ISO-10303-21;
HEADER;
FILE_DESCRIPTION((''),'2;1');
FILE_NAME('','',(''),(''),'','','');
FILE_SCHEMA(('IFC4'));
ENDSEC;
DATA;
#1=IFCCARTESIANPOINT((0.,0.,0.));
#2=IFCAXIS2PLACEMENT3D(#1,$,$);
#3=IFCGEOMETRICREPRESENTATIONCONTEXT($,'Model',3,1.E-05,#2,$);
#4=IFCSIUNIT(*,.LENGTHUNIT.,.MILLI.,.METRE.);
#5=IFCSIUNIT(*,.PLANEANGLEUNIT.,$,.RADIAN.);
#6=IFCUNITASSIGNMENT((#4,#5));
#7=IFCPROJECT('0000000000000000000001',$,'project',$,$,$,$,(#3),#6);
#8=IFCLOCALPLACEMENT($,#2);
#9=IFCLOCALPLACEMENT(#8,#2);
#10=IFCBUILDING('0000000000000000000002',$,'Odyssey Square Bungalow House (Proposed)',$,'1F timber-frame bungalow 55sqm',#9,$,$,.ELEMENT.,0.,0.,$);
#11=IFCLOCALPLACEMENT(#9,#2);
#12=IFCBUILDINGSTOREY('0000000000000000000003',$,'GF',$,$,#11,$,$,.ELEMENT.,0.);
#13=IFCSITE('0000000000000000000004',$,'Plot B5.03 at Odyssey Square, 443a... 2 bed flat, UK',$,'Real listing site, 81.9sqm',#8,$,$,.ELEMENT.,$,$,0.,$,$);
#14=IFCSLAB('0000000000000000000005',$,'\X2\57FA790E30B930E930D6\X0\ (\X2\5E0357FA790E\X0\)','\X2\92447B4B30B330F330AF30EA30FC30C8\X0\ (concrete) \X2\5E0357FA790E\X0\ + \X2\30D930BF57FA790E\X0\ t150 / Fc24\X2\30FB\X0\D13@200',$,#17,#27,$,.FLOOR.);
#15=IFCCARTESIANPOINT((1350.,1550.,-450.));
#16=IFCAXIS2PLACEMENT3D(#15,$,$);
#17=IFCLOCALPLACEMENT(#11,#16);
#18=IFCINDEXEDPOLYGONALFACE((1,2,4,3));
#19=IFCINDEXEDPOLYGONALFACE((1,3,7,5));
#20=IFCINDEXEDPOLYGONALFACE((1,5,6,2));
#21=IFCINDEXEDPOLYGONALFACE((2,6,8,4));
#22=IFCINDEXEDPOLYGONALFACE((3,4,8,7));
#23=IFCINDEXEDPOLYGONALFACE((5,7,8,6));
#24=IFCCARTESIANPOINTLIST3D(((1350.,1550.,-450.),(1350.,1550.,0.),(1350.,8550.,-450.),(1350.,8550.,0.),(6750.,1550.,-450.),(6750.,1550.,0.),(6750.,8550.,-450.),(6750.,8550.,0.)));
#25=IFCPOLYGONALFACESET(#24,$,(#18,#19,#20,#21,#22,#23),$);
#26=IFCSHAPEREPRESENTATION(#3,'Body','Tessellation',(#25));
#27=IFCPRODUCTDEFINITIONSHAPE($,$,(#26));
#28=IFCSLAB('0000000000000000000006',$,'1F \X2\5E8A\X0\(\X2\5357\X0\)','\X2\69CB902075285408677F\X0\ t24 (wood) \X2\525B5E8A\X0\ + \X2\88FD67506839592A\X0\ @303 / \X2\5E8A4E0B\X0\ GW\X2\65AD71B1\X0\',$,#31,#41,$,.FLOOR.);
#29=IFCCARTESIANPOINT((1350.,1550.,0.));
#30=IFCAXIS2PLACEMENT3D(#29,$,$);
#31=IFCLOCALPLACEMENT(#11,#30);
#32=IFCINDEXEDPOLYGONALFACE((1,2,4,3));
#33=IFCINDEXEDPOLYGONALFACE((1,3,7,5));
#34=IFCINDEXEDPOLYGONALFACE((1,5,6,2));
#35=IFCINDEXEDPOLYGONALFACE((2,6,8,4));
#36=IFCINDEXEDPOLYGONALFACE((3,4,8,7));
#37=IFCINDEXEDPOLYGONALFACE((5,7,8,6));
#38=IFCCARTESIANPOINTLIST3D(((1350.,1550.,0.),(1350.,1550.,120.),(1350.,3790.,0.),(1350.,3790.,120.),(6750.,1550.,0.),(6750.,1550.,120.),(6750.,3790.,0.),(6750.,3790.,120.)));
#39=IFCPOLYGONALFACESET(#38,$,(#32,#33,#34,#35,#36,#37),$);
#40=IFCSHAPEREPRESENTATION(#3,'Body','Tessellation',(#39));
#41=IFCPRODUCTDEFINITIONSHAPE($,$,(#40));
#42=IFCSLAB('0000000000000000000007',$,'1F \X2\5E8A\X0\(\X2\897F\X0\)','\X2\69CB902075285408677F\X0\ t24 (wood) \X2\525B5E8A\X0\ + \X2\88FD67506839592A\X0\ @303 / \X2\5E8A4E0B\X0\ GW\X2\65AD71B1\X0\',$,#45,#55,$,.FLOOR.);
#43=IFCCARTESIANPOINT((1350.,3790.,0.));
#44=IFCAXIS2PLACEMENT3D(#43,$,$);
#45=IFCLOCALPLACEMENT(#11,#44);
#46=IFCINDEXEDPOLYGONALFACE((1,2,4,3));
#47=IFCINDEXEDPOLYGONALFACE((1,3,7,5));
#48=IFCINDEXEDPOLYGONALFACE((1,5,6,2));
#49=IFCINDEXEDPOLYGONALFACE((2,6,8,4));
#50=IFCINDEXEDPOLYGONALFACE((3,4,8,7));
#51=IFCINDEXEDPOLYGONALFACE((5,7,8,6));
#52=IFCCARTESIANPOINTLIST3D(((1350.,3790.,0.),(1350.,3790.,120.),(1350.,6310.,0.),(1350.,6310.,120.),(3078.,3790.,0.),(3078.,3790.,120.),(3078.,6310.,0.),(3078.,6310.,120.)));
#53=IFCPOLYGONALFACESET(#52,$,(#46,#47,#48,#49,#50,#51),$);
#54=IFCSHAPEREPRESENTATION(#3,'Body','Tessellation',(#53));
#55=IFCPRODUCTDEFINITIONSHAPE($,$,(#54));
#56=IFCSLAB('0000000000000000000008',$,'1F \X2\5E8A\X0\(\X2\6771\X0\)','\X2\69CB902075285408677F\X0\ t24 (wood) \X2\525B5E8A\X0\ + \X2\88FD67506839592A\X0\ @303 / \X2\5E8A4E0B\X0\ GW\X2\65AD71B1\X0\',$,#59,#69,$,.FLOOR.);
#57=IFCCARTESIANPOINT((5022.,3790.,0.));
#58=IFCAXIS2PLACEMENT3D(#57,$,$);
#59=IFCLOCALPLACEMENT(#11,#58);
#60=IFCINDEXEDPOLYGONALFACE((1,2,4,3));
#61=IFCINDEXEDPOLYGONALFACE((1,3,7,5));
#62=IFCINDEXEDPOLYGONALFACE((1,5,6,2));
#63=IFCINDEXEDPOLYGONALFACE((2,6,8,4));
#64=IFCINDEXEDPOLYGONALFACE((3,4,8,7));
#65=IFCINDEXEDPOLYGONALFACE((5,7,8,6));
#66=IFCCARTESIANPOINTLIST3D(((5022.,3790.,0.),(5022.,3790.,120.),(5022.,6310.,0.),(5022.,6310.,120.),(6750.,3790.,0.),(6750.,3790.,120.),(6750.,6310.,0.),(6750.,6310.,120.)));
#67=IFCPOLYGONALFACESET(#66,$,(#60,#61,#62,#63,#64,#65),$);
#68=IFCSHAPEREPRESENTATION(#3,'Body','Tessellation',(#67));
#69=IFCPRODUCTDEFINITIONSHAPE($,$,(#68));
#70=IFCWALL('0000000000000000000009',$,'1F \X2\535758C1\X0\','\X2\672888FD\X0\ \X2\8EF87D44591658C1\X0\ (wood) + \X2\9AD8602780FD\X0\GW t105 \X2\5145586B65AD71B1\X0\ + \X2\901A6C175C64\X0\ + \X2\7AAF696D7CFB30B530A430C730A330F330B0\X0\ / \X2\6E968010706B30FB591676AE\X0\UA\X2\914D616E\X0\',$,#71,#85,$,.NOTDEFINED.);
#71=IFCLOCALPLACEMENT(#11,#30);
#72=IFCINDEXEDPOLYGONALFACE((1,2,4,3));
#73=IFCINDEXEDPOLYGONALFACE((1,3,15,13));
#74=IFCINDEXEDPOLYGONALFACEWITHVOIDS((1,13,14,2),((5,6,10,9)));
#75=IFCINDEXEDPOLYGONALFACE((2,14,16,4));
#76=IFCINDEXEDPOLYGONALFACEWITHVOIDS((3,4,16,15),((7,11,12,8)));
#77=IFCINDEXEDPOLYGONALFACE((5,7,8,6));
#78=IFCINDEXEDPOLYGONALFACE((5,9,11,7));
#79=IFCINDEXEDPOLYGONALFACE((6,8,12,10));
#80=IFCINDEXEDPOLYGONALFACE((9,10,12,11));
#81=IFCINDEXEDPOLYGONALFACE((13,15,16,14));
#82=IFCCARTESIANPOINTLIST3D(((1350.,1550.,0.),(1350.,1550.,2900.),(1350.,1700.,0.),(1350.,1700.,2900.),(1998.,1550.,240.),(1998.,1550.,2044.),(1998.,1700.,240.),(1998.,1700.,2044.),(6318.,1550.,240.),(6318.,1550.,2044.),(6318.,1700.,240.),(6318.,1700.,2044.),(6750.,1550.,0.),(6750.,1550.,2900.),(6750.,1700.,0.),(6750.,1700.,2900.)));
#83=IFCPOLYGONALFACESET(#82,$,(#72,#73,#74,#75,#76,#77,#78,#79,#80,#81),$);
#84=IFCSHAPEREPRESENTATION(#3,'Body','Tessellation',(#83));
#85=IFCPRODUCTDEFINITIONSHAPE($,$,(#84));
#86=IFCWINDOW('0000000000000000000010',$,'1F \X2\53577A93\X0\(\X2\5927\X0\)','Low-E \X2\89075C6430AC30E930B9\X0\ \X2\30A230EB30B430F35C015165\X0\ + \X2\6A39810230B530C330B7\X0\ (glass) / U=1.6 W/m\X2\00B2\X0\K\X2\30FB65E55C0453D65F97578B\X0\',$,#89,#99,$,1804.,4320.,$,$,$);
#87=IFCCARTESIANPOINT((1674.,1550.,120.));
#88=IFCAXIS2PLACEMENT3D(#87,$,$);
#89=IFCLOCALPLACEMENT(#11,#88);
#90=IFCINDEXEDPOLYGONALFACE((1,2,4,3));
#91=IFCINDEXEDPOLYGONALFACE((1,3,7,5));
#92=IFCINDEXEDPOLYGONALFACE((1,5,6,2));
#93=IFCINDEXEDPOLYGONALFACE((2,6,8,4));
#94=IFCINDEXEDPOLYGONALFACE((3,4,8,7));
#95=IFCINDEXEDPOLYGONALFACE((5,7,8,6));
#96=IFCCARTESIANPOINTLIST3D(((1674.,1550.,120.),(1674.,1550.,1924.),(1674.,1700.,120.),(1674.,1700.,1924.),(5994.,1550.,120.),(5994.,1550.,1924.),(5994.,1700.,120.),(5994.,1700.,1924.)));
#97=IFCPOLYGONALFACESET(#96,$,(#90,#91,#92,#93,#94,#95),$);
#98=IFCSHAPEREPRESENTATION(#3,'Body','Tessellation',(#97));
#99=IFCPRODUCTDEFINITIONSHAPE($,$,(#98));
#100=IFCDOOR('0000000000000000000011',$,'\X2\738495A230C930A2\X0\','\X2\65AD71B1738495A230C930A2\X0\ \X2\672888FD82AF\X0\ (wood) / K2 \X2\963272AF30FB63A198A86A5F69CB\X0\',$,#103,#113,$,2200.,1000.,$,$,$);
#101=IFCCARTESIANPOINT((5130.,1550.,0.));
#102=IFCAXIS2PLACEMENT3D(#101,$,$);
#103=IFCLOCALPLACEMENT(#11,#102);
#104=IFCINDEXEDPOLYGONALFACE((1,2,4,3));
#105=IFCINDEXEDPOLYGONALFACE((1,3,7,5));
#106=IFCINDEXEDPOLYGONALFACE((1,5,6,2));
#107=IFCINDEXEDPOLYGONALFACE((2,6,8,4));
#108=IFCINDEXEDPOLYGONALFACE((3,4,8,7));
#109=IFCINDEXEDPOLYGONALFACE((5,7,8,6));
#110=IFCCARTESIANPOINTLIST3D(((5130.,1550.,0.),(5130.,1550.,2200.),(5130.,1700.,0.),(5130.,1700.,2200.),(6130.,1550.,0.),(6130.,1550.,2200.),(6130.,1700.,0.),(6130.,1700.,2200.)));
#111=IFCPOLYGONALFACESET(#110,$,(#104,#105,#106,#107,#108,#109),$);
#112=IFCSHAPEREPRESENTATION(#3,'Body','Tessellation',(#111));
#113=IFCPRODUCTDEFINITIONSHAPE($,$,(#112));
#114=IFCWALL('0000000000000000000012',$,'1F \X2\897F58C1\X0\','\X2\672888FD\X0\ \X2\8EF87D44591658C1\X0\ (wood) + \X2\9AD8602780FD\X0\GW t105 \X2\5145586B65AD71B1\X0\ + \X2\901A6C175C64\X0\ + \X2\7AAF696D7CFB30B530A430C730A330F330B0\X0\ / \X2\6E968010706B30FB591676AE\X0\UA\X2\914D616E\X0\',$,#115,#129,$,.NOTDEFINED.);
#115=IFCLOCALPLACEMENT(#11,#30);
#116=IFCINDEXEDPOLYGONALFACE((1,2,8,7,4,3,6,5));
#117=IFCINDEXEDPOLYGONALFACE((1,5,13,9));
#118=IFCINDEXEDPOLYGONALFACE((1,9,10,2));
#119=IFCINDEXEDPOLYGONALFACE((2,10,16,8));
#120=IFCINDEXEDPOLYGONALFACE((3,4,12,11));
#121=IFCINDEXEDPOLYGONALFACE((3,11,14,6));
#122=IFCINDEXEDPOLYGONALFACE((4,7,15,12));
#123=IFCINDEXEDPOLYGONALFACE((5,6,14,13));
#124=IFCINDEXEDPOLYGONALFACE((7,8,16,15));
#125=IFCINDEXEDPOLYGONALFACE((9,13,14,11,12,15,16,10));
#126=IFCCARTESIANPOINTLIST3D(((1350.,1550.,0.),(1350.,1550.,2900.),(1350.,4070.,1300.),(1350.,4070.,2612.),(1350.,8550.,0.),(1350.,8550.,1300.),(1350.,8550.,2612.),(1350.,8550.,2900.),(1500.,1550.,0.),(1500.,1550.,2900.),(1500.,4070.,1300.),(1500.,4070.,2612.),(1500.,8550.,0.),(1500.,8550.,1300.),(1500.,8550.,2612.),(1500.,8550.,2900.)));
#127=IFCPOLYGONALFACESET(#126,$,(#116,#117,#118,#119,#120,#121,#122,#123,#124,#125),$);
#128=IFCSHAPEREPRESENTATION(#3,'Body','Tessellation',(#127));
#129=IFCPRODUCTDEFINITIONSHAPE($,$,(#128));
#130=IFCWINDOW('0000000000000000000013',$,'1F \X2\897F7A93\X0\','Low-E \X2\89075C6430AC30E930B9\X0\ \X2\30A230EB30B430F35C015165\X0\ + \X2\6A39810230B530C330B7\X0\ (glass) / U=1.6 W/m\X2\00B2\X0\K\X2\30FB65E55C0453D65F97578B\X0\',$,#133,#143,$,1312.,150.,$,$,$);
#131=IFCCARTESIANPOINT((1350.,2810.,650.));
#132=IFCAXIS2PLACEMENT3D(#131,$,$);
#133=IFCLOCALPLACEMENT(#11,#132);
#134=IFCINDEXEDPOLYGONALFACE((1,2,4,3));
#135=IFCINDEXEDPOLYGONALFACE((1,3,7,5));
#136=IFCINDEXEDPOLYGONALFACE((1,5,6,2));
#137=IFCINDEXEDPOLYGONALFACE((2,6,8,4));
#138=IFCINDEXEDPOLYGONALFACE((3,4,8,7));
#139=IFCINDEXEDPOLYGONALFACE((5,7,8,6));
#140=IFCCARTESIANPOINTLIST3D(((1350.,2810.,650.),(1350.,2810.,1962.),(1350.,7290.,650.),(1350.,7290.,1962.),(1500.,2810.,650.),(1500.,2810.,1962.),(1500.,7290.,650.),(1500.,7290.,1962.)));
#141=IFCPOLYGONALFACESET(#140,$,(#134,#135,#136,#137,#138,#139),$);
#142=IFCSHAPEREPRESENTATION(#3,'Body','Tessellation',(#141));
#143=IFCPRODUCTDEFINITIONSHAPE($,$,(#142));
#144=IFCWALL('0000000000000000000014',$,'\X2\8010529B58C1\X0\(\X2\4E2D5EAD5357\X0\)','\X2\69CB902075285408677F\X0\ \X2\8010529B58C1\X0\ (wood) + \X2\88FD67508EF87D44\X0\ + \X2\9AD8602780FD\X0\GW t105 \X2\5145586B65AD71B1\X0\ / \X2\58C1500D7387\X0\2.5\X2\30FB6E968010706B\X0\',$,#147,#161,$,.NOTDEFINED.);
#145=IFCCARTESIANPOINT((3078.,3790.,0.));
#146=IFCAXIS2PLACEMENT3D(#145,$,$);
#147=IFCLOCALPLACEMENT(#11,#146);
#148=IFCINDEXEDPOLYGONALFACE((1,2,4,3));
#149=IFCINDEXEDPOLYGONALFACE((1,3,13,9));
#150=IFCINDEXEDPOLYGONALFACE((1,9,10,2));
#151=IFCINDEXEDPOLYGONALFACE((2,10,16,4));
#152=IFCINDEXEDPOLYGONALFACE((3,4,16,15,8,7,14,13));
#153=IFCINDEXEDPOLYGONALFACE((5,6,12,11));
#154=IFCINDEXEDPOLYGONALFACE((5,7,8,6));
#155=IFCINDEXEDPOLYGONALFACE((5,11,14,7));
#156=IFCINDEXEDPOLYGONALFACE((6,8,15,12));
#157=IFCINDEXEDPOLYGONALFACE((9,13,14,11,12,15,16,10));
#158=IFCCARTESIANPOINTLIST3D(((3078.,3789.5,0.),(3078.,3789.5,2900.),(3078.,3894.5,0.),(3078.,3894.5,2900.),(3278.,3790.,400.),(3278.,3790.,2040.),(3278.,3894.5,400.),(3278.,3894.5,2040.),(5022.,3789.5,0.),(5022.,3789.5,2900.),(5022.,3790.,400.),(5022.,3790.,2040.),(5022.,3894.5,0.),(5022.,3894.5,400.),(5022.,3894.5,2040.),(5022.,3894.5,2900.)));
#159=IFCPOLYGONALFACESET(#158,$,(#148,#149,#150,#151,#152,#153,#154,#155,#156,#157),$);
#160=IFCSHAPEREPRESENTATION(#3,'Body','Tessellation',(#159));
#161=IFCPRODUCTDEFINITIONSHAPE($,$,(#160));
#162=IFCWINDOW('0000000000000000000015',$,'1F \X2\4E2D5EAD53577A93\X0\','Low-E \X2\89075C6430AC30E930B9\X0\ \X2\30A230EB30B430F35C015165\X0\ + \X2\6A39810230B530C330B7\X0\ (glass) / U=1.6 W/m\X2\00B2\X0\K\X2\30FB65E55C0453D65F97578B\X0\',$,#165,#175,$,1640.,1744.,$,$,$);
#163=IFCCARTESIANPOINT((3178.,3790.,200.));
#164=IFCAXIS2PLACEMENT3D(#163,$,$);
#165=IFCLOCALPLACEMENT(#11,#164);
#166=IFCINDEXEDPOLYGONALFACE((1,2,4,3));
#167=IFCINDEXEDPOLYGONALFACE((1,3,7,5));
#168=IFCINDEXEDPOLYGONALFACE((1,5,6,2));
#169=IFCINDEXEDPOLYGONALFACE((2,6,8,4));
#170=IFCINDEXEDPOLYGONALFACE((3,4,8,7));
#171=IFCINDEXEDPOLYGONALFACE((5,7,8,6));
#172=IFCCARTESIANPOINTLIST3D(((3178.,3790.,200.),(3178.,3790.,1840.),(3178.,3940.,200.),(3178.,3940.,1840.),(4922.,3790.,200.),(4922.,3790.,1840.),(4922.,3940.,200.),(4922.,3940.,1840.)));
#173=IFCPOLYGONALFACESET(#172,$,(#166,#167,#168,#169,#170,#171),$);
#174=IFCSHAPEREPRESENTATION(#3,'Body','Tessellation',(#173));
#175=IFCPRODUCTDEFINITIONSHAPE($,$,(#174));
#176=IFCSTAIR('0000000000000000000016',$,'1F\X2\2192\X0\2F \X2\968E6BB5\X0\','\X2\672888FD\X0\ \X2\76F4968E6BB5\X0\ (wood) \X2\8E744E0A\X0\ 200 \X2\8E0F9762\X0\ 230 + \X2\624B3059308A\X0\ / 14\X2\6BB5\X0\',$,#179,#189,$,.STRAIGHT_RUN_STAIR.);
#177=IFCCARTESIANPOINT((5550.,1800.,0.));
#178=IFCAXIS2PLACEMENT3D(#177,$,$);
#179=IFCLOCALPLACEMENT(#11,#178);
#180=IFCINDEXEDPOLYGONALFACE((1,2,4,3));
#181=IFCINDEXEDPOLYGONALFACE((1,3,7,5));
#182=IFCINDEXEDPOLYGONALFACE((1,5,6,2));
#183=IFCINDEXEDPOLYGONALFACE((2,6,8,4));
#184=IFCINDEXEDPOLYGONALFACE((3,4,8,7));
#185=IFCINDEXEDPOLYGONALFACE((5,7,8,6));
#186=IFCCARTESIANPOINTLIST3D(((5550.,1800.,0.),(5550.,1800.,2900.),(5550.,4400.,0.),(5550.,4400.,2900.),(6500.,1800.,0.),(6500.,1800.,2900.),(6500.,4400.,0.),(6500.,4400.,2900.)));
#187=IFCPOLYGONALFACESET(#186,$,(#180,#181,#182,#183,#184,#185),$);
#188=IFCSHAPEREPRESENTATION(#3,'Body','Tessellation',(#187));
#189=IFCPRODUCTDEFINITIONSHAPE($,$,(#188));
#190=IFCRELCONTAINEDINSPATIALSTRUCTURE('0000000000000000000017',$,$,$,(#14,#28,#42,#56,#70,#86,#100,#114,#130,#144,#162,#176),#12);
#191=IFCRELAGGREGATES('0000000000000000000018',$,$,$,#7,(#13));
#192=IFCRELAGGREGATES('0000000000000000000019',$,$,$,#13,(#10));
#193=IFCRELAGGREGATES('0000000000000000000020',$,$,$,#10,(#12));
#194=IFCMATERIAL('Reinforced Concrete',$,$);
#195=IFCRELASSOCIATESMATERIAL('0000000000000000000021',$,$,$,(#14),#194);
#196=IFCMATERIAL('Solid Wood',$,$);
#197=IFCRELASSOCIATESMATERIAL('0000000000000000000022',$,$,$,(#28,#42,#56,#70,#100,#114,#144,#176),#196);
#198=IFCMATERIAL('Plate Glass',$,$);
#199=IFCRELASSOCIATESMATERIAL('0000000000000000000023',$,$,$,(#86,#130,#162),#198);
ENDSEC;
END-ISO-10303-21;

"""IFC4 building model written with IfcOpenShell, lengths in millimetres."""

from ifc_helpers import new_model, si_unit, frame, frame_2d, origin, place, context, project, spatial, rectangle, extrude, material, element, fill, save


model = new_model("IFC4")

# Units and contexts
model_context = context("Model", 3, precision=1e-05, world=origin())
ifc_project = project(units=[si_unit("LENGTHUNIT", "METRE", prefix="MILLI"), si_unit("PLANEANGLEUNIT", "RADIAN")], contexts=[model_context])

# Site, building, storey
site_placement = place(None, origin())
site = spatial("IfcSite", under=ifc_project, at=site_placement, Name="Plot B5.03 at Odyssey Square, 443a... 2 bed flat, UK", ObjectType="Real listing site, 81.9sqm", CompositionType="ELEMENT", RefElevation=0.0)
building_placement = place(site_placement, origin())
building = spatial("IfcBuilding", under=site, at=building_placement, Name="Odyssey Square Bungalow House (Proposed)", ObjectType="1F timber-frame bungalow 55sqm", CompositionType="ELEMENT", ElevationOfRefHeight=0.0, ElevationOfTerrain=0.0)
storey_placement = place(building_placement, origin())
storey = spatial("IfcBuildingStorey", under=building, at=storey_placement, Name="GF", CompositionType="ELEMENT", Elevation=0.0)

# Slabs
ifc_material_1 = material(Name="Reinforced Concrete")
slab_1_placement = place(storey_placement, frame((1350.0, 1550.0, -450.0)))
element("IfcSlab", 1, at=slab_1_placement, inside=storey, material=ifc_material_1, Name="基礎スラブ (布基礎)", Description="鉄筋コンクリート (concrete) 布基礎 + ベタ基礎 t150 / Fc24・D13@200", PredefinedType="FLOOR", context=model_context, shape_type="SweptSolid", body=[
    extrude(rectangle(XDim=5400.0, YDim=7000.0, at=frame_2d((2700.0, 3500.0))), frame((1350.0, 1550.0, -450.0)), (0.0, 0.0, 1.0), 450.0),
])
ifc_material_2 = material(Name="Solid Wood")
slab_2_placement = place(storey_placement, frame((1350.0, 1550.0, 0.0)))
element("IfcSlab", 2, at=slab_2_placement, inside=storey, material=ifc_material_2, Name="1F 床(南)", Description="構造用合板 t24 (wood) 剛床 + 製材根太 @303 / 床下 GW断熱", PredefinedType="FLOOR", context=model_context, shape_type="SweptSolid", body=[
    extrude(rectangle(XDim=5400.0, YDim=2240.0, at=frame_2d((2700.0, 1120.0))), frame((1350.0, 1550.0, 0.0)), (0.0, 0.0, 1.0), 120.0),
])
slab_3_placement = place(storey_placement, frame((1350.0, 3790.0, 0.0)))
element("IfcSlab", 3, at=slab_3_placement, inside=storey, material=ifc_material_2, Name="1F 床(西)", Description="構造用合板 t24 (wood) 剛床 + 製材根太 @303 / 床下 GW断熱", PredefinedType="FLOOR", context=model_context, shape_type="SweptSolid", body=[
    extrude(rectangle(XDim=1728.0, YDim=2520.0, at=frame_2d((864.0, 1260.0))), frame((1350.0, 3790.0, 0.0)), (0.0, 0.0, 1.0), 120.0),
])
slab_4_placement = place(storey_placement, frame((5022.0, 3790.0, 0.0)))
element("IfcSlab", 4, at=slab_4_placement, inside=storey, material=ifc_material_2, Name="1F 床(東)", Description="構造用合板 t24 (wood) 剛床 + 製材根太 @303 / 床下 GW断熱", PredefinedType="FLOOR", context=model_context, shape_type="SweptSolid", body=[
    extrude(rectangle(XDim=1728.0, YDim=2520.0, at=frame_2d((864.0, 1260.0))), frame((5022.0, 3790.0, 0.0)), (0.0, 0.0, 1.0), 120.0),
])

# Wall, openings, window, door
wall_1_placement = place(storey_placement, frame((1350.0, 1550.0, 0.0)))
wall_1 = element("IfcWall", 5, at=wall_1_placement, inside=storey, material=ifc_material_2, Name="1F 南壁", Description="木製 軸組外壁 (wood) + 高性能GW t105 充填断熱 + 通気層 + 窯業系サイディング / 準耐火・外皮UA配慮", PredefinedType="NOTDEFINED", context=model_context, shape_type="SweptSolid", body=[
    extrude(rectangle(XDim=5400.0, YDim=150.0, at=frame_2d((2700.0, 75.0))), frame((1350.0, 1550.0, 0.0)), (0.0, 0.0, 1.0), 2900.0),
])
opening_1_placement = place(storey_placement, frame((1674.0, 1550.0, 120.0)))
opening_1 = element("IfcOpeningElement", 6, at=opening_1_placement, cuts=wall_1, PredefinedType="NOTDEFINED", context=model_context, shape_type="SweptSolid", body=[
    extrude(rectangle(XDim=4320.0, YDim=150.0, at=frame_2d((2160.0, 75.0))), frame((1674.0, 1550.0, 120.0)), (0.0, 0.0, 1.0), 1804.0),
])
opening_2_placement = place(storey_placement, frame((5130.0, 1550.0, 0.0)))
opening_2 = element("IfcOpeningElement", 7, at=opening_2_placement, cuts=wall_1, PredefinedType="NOTDEFINED", context=model_context, shape_type="SweptSolid", body=[
    extrude(rectangle(XDim=1000.0, YDim=150.0, at=frame_2d((500.0, 75.0))), frame((5130.0, 1550.0, 0.0)), (0.0, 0.0, 1.0), 2200.0),
])
ifc_material_3 = material(Name="Plate Glass")
window_1_placement = place(storey_placement, frame((1674.0, 1550.0, 120.0)))
window_1 = element("IfcWindow", 8, at=window_1_placement, inside=storey, material=ifc_material_3, Name="1F 南窓(大)", Description="Low-E 複層ガラス アルゴン封入 + 樹脂サッシ (glass) / U=1.6 W/m²K・日射取得型", OverallHeight=1804.0, OverallWidth=4320.0, context=model_context, shape_type="SweptSolid", body=[
    extrude(rectangle(XDim=4320.0, YDim=150.0, at=frame_2d((2160.0, 75.0))), frame((1674.0, 1550.0, 120.0)), (0.0, 0.0, 1.0), 1804.0),
])
fill(opening_1, window_1)
door_placement = place(storey_placement, frame((5130.0, 1550.0, 0.0)))
door = element("IfcDoor", 9, at=door_placement, inside=storey, material=ifc_material_2, Name="玄関ドア", Description="断熱玄関ドア 木製芯 (wood) / K2 防犯・採風機構", OverallHeight=2200.0, OverallWidth=1000.0, context=model_context, shape_type="SweptSolid", body=[
    extrude(rectangle(XDim=1000.0, YDim=150.0, at=frame_2d((500.0, 75.0))), frame((5130.0, 1550.0, 0.0)), (0.0, 0.0, 1.0), 2200.0),
])
fill(opening_2, door)

# Walls, openings, windows
wall_2_placement = place(storey_placement, frame((1350.0, 1550.0, 0.0)))
wall_2 = element("IfcWall", 10, at=wall_2_placement, inside=storey, material=ifc_material_2, Name="1F 西壁", Description="木製 軸組外壁 (wood) + 高性能GW t105 充填断熱 + 通気層 + 窯業系サイディング / 準耐火・外皮UA配慮", PredefinedType="NOTDEFINED", context=model_context, shape_type="SweptSolid", body=[
    extrude(rectangle(XDim=150.0, YDim=7000.0, at=frame_2d((75.0, 3500.0))), frame((1350.0, 1550.0, 0.0)), (0.0, 0.0, 1.0), 2900.0),
])
opening_3_placement = place(storey_placement, frame((1350.0, 2810.0, 650.0)))
opening_3 = element("IfcOpeningElement", 11, at=opening_3_placement, cuts=wall_2, PredefinedType="NOTDEFINED", context=model_context, shape_type="SweptSolid", body=[
    extrude(rectangle(XDim=150.0, YDim=4480.0, at=frame_2d((75.0, 2240.0))), frame((1350.0, 2810.0, 650.0)), (0.0, 0.0, 1.0), 1312.0),
])
window_2_placement = place(storey_placement, frame((1350.0, 2810.0, 650.0)))
window_2 = element("IfcWindow", 12, at=window_2_placement, inside=storey, material=ifc_material_3, Name="1F 西窓", Description="Low-E 複層ガラス アルゴン封入 + 樹脂サッシ (glass) / U=1.6 W/m²K・日射取得型", OverallHeight=1312.0, OverallWidth=150.0, context=model_context, shape_type="SweptSolid", body=[
    extrude(rectangle(XDim=150.0, YDim=4480.0, at=frame_2d((75.0, 2240.0))), frame((1350.0, 2810.0, 650.0)), (0.0, 0.0, 1.0), 1312.0),
])
fill(opening_3, window_2)
wall_3_placement = place(storey_placement, frame((3078.0, 3790.0, 0.0)))
wall_3 = element("IfcWall", 13, at=wall_3_placement, inside=storey, material=ifc_material_2, Name="耐力壁(中庭南)", Description="構造用合板 耐力壁 (wood) + 製材軸組 + 高性能GW t105 充填断熱 / 壁倍率2.5・準耐火", PredefinedType="NOTDEFINED", context=model_context, shape_type="SweptSolid", body=[
    extrude(rectangle(XDim=1944.0, YDim=105.0, at=frame_2d((972.0, 52.0))), frame((3078.0, 3790.0, 0.0)), (0.0, 0.0, 1.0), 2900.0),
])
opening_4_placement = place(storey_placement, frame((3178.0, 3790.0, 200.0)))
opening_4 = element("IfcOpeningElement", 14, at=opening_4_placement, cuts=wall_3, PredefinedType="NOTDEFINED", context=model_context, shape_type="SweptSolid", body=[
    extrude(rectangle(XDim=1744.0, YDim=150.0, at=frame_2d((872.0, 75.0))), frame((3178.0, 3790.0, 200.0)), (0.0, 0.0, 1.0), 1640.0),
])
window_3_placement = place(storey_placement, frame((3178.0, 3790.0, 200.0)))
window_3 = element("IfcWindow", 15, at=window_3_placement, inside=storey, material=ifc_material_3, Name="1F 中庭南窓", Description="Low-E 複層ガラス アルゴン封入 + 樹脂サッシ (glass) / U=1.6 W/m²K・日射取得型", OverallHeight=1640.0, OverallWidth=1744.0, context=model_context, shape_type="SweptSolid", body=[
    extrude(rectangle(XDim=1744.0, YDim=150.0, at=frame_2d((872.0, 75.0))), frame((3178.0, 3790.0, 200.0)), (0.0, 0.0, 1.0), 1640.0),
])
fill(opening_4, window_3)

# Stair
stair_placement = place(storey_placement, frame((5550.0, 1800.0, 0.0)))
element("IfcStair", 16, at=stair_placement, inside=storey, material=ifc_material_2, Name="1F→2F 階段", Description="木製 直階段 (wood) 蹴上 200 踏面 230 + 手すり / 14段", PredefinedType="STRAIGHT_RUN_STAIR", context=model_context, shape_type="SweptSolid", body=[
    extrude(rectangle(XDim=950.0, YDim=2600.0, at=frame_2d((475.0, 1300.0))), frame((5550.0, 1800.0, 0.0)), (0.0, 0.0, 1.0), 2900.0),
])

save(model, "model.ifc")
